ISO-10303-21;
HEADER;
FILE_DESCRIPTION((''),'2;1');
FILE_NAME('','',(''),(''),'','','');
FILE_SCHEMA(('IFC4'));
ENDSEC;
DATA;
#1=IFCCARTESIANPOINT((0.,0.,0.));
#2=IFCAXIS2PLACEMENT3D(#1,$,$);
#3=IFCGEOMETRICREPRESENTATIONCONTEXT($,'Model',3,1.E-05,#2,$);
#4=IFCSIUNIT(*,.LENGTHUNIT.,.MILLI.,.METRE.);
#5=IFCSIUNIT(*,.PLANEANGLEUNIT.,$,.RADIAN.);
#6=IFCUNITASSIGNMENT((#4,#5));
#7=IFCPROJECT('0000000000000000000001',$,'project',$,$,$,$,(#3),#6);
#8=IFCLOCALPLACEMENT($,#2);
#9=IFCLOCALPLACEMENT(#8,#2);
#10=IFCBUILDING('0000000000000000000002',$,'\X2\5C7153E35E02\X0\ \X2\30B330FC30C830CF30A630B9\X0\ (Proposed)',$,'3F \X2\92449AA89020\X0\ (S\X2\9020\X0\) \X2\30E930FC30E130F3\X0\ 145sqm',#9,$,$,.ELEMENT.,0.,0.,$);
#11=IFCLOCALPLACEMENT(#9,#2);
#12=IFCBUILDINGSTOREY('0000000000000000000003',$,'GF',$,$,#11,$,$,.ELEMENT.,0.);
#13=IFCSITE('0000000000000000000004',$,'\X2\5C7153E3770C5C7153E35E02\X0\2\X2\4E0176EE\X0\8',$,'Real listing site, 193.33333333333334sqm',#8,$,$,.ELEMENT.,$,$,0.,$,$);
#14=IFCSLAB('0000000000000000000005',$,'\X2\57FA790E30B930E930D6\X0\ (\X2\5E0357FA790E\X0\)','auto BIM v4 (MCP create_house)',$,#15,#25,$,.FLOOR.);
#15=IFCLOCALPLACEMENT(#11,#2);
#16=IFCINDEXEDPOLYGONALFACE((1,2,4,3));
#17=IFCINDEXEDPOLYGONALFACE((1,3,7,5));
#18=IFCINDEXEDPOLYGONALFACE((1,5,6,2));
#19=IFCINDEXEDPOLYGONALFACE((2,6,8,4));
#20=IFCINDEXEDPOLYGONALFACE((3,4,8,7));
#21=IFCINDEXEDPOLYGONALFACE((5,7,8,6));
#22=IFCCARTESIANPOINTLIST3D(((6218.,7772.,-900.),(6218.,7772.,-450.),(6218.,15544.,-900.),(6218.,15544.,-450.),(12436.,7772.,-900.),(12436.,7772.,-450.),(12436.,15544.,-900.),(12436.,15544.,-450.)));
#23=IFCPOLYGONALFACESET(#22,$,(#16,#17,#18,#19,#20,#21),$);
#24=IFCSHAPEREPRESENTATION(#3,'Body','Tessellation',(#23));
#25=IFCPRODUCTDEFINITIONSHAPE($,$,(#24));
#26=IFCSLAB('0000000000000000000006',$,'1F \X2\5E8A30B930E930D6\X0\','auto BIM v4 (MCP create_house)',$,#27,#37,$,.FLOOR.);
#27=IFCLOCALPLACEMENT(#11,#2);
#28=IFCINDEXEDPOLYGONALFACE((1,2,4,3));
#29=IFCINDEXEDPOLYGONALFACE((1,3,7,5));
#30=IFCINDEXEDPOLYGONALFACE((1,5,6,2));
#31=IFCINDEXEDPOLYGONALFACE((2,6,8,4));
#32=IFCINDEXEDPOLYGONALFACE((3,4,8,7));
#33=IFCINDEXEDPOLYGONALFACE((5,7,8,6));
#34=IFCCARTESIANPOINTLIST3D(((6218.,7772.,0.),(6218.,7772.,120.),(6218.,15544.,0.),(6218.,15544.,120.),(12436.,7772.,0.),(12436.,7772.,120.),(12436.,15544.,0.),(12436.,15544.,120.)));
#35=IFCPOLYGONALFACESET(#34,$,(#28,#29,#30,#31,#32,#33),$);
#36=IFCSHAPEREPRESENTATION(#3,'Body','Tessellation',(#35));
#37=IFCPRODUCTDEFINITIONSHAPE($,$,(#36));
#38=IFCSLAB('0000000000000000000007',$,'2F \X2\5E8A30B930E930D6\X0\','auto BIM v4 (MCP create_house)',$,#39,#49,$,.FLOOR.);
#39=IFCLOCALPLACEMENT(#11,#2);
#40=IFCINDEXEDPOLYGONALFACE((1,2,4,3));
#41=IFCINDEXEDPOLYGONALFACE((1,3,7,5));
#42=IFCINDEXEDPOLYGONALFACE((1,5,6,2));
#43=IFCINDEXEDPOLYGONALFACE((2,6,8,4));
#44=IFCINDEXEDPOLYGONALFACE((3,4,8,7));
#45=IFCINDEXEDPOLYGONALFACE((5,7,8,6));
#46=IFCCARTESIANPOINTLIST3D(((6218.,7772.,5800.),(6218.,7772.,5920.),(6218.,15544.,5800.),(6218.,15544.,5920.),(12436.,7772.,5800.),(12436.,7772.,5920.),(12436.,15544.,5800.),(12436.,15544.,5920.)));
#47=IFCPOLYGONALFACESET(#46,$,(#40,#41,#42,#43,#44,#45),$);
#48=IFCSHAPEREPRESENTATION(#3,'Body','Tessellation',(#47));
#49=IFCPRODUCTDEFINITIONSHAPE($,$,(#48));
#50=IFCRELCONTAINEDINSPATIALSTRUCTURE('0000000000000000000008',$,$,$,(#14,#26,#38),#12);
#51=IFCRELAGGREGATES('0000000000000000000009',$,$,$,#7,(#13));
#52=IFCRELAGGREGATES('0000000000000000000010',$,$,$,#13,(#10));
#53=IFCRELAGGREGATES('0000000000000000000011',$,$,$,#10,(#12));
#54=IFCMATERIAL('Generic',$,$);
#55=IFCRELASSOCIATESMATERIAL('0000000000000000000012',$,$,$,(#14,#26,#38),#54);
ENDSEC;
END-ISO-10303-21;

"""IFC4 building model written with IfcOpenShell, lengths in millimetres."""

from ifc_helpers import new_model, si_unit, frame, frame_2d, origin, place, context, project, spatial, rectangle, extrude, material, element, save


model = new_model("IFC4")

# Units and contexts
model_context = context("Model", 3, precision=1e-05, world=origin())
ifc_project = project(units=[si_unit("LENGTHUNIT", "METRE", prefix="MILLI"), si_unit("PLANEANGLEUNIT", "RADIAN")], contexts=[model_context])

# Site, building, storey
site_placement = place(None, origin())
site = spatial("IfcSite", under=ifc_project, at=site_placement, Name="山口県山口市2丁目8", ObjectType="Real listing site, 193.33333333333334sqm", CompositionType="ELEMENT", RefElevation=0.0)
building_placement = place(site_placement, origin())
building = spatial("IfcBuilding", under=site, at=building_placement, Name="山口市 コートハウス (Proposed)", ObjectType="3F 鉄骨造 (S造) ラーメン 145sqm", CompositionType="ELEMENT", ElevationOfRefHeight=0.0, ElevationOfTerrain=0.0)
storey_placement = place(building_placement, origin())
storey = spatial("IfcBuildingStorey", under=building, at=storey_placement, Name="GF", CompositionType="ELEMENT", Elevation=0.0)

# Slabs
ifc_material = material(Name="Generic")
slab_1_placement = place(storey_placement, frame((3109.0, 3886.0, -450.0)))
element("IfcSlab", 1, at=slab_1_placement, inside=storey, material=ifc_material, Name="基礎スラブ (布基礎)", Description="auto BIM v4 (MCP create_house)", PredefinedType="FLOOR", context=model_context, shape_type="SweptSolid", body=[
    extrude(rectangle(XDim=6218.0, YDim=7772.0, at=frame_2d((3109.0, 3886.0))), frame((3109.0, 3886.0, -450.0)), (0.0, 0.0, 1.0), 450.0),
])
slab_2_placement = place(storey_placement, frame((3109.0, 3886.0, 0.0)))
element("IfcSlab", 2, at=slab_2_placement, inside=storey, material=ifc_material, Name="1F 床スラブ", Description="auto BIM v4 (MCP create_house)", PredefinedType="FLOOR", context=model_context, shape_type="SweptSolid", body=[
    extrude(rectangle(XDim=6218.0, YDim=7772.0, at=frame_2d((3109.0, 3886.0))), frame((3109.0, 3886.0, 0.0)), (0.0, 0.0, 1.0), 120.0),
])
slab_3_placement = place(storey_placement, frame((3109.0, 3886.0, 2900.0)))
element("IfcSlab", 3, at=slab_3_placement, inside=storey, material=ifc_material, Name="2F 床スラブ", Description="auto BIM v4 (MCP create_house)", PredefinedType="FLOOR", context=model_context, shape_type="SweptSolid", body=[
    extrude(rectangle(XDim=6218.0, YDim=7772.0, at=frame_2d((3109.0, 3886.0))), frame((3109.0, 3886.0, 2900.0)), (0.0, 0.0, 1.0), 120.0),
])

save(model, "model.ifc")
